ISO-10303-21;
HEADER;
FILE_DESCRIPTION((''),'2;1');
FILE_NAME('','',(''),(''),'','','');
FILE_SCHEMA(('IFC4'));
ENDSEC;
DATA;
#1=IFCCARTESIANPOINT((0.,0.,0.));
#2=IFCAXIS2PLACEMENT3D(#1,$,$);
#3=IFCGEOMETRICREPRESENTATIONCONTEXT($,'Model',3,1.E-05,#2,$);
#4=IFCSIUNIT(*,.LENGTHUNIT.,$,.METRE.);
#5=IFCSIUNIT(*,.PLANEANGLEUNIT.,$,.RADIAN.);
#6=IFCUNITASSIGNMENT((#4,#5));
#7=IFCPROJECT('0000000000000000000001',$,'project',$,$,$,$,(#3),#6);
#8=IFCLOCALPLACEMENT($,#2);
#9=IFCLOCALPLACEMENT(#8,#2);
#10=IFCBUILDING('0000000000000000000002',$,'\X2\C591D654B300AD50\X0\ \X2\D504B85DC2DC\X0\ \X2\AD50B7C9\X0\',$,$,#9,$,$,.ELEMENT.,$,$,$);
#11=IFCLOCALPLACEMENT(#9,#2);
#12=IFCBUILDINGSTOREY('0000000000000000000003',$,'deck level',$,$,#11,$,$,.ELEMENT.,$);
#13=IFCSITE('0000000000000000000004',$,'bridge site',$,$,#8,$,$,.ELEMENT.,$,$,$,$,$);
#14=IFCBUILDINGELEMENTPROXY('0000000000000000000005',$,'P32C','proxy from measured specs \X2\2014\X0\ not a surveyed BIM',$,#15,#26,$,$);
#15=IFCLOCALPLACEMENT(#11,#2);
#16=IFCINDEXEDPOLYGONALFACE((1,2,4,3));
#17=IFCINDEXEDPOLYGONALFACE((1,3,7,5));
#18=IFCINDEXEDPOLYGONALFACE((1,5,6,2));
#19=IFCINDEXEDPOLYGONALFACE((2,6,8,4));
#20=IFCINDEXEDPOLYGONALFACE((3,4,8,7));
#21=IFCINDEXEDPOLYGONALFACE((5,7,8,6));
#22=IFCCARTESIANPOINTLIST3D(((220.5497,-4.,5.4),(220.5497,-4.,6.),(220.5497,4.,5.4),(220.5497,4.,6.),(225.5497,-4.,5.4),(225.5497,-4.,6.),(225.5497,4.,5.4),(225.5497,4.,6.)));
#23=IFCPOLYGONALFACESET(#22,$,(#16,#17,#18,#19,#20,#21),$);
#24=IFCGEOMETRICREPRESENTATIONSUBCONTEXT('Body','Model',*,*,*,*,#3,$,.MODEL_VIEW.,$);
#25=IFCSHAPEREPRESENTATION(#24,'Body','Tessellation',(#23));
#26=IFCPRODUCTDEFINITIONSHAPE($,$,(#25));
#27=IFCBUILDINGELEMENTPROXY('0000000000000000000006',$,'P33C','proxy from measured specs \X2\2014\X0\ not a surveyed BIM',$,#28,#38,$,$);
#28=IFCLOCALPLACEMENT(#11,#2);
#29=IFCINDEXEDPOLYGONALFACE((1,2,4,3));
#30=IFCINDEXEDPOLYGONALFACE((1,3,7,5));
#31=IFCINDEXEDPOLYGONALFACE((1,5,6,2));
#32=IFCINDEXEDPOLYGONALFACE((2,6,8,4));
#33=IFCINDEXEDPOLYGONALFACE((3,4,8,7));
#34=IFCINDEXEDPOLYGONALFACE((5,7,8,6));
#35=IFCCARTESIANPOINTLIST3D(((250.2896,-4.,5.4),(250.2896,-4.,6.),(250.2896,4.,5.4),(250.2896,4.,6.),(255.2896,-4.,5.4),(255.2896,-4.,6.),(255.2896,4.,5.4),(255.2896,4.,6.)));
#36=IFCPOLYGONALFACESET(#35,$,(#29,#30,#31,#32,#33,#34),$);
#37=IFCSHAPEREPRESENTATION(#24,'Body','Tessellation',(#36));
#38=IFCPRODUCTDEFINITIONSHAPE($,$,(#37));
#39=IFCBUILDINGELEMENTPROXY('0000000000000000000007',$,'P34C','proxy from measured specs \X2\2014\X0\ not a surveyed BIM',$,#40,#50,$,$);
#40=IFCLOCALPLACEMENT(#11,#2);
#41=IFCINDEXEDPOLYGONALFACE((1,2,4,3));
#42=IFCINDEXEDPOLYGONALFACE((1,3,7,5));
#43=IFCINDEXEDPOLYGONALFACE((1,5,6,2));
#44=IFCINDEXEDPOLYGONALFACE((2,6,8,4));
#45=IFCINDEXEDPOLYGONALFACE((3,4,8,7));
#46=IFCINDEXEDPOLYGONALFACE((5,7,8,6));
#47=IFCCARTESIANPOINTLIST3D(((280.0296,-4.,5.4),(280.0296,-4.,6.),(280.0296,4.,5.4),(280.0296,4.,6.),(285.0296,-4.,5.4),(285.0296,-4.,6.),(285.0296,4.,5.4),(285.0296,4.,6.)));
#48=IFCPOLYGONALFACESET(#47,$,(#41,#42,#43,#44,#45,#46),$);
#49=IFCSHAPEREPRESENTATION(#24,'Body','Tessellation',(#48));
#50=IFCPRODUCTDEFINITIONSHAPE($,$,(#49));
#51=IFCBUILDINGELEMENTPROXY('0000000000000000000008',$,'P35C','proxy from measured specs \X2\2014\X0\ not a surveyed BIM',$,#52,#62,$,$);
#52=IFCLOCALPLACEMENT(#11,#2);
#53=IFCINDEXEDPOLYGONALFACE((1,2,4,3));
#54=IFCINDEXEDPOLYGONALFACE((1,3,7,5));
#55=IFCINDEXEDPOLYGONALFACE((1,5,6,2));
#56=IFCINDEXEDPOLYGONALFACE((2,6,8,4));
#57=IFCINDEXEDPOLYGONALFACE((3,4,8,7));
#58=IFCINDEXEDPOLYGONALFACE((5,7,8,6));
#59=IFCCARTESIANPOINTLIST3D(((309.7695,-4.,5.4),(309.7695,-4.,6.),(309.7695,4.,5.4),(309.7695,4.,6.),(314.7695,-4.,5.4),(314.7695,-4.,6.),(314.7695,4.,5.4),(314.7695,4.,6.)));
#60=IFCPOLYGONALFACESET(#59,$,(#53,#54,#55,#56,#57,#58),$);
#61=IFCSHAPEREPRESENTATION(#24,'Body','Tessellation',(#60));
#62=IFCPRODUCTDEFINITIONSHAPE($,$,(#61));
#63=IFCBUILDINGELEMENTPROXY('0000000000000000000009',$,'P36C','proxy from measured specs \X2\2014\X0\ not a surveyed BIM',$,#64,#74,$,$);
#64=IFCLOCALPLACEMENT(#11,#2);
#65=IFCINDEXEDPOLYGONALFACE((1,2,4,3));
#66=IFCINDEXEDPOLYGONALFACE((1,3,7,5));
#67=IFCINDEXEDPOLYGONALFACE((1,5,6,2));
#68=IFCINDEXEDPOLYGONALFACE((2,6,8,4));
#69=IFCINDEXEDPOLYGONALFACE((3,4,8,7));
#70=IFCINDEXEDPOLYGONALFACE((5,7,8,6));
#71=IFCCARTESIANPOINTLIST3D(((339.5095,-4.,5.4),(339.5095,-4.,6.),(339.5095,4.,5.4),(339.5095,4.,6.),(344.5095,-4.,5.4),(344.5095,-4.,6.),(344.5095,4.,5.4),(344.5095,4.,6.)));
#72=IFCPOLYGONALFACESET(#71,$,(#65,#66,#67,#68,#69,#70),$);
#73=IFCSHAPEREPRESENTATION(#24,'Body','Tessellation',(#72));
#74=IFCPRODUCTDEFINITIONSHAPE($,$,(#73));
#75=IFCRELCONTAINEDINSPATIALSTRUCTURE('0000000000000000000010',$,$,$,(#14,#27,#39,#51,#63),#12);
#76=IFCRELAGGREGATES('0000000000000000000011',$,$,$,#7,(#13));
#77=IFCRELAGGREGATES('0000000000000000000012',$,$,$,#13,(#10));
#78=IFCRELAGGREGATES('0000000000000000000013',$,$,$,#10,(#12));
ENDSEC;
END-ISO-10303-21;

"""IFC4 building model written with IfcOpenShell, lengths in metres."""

from ifc_helpers import new_model, si_unit, frame, origin, origin_2d, place, context, subcontext, project, spatial, rectangle, extrude, element, save


model = new_model("IFC4")

# Units and contexts
model_context = context("Model", 3, precision=1e-05, world=origin())
body_context = subcontext(model_context, "Body", "Model", "MODEL_VIEW")
ifc_project = project(units=[si_unit("LENGTHUNIT", "METRE"), si_unit("PLANEANGLEUNIT", "RADIAN")], contexts=[model_context])

# Site, building, storey
site_placement = place(None, origin())
site = spatial("IfcSite", under=ifc_project, at=site_placement, Name="bridge site", CompositionType="ELEMENT")
building_placement = place(site_placement, origin())
building = spatial("IfcBuilding", under=site, at=building_placement, Name="양화대교 프록시 교량", CompositionType="ELEMENT")
storey_placement = place(building_placement, origin())
storey = spatial("IfcBuildingStorey", under=building, at=storey_placement, Name="deck level", CompositionType="ELEMENT")

# Building element proxies
for number, where, name in (
    (1, (223.0497, 0.0, 5.4), "P32C"),
    (2, (252.7896, 0.0, 5.4), "P33C"),
    (3, (282.5296, 0.0, 5.4), "P34C"),
    (4, (312.2695, 0.0, 5.4), "P35C"),
    (5, (342.0095, 0.0, 5.4), "P36C"),
):
    element("IfcBuildingElementProxy", number, at=place(storey_placement, frame(where)), inside=storey, Name=name, Description="proxy from measured specs — not a surveyed BIM", context=body_context, shape_type="SweptSolid", body=[
        extrude(rectangle(XDim=5.0, YDim=8.0, at=origin_2d()), origin(), (0.0, 0.0, 1.0), 0.6),
    ])

save(model, "model.ifc")
